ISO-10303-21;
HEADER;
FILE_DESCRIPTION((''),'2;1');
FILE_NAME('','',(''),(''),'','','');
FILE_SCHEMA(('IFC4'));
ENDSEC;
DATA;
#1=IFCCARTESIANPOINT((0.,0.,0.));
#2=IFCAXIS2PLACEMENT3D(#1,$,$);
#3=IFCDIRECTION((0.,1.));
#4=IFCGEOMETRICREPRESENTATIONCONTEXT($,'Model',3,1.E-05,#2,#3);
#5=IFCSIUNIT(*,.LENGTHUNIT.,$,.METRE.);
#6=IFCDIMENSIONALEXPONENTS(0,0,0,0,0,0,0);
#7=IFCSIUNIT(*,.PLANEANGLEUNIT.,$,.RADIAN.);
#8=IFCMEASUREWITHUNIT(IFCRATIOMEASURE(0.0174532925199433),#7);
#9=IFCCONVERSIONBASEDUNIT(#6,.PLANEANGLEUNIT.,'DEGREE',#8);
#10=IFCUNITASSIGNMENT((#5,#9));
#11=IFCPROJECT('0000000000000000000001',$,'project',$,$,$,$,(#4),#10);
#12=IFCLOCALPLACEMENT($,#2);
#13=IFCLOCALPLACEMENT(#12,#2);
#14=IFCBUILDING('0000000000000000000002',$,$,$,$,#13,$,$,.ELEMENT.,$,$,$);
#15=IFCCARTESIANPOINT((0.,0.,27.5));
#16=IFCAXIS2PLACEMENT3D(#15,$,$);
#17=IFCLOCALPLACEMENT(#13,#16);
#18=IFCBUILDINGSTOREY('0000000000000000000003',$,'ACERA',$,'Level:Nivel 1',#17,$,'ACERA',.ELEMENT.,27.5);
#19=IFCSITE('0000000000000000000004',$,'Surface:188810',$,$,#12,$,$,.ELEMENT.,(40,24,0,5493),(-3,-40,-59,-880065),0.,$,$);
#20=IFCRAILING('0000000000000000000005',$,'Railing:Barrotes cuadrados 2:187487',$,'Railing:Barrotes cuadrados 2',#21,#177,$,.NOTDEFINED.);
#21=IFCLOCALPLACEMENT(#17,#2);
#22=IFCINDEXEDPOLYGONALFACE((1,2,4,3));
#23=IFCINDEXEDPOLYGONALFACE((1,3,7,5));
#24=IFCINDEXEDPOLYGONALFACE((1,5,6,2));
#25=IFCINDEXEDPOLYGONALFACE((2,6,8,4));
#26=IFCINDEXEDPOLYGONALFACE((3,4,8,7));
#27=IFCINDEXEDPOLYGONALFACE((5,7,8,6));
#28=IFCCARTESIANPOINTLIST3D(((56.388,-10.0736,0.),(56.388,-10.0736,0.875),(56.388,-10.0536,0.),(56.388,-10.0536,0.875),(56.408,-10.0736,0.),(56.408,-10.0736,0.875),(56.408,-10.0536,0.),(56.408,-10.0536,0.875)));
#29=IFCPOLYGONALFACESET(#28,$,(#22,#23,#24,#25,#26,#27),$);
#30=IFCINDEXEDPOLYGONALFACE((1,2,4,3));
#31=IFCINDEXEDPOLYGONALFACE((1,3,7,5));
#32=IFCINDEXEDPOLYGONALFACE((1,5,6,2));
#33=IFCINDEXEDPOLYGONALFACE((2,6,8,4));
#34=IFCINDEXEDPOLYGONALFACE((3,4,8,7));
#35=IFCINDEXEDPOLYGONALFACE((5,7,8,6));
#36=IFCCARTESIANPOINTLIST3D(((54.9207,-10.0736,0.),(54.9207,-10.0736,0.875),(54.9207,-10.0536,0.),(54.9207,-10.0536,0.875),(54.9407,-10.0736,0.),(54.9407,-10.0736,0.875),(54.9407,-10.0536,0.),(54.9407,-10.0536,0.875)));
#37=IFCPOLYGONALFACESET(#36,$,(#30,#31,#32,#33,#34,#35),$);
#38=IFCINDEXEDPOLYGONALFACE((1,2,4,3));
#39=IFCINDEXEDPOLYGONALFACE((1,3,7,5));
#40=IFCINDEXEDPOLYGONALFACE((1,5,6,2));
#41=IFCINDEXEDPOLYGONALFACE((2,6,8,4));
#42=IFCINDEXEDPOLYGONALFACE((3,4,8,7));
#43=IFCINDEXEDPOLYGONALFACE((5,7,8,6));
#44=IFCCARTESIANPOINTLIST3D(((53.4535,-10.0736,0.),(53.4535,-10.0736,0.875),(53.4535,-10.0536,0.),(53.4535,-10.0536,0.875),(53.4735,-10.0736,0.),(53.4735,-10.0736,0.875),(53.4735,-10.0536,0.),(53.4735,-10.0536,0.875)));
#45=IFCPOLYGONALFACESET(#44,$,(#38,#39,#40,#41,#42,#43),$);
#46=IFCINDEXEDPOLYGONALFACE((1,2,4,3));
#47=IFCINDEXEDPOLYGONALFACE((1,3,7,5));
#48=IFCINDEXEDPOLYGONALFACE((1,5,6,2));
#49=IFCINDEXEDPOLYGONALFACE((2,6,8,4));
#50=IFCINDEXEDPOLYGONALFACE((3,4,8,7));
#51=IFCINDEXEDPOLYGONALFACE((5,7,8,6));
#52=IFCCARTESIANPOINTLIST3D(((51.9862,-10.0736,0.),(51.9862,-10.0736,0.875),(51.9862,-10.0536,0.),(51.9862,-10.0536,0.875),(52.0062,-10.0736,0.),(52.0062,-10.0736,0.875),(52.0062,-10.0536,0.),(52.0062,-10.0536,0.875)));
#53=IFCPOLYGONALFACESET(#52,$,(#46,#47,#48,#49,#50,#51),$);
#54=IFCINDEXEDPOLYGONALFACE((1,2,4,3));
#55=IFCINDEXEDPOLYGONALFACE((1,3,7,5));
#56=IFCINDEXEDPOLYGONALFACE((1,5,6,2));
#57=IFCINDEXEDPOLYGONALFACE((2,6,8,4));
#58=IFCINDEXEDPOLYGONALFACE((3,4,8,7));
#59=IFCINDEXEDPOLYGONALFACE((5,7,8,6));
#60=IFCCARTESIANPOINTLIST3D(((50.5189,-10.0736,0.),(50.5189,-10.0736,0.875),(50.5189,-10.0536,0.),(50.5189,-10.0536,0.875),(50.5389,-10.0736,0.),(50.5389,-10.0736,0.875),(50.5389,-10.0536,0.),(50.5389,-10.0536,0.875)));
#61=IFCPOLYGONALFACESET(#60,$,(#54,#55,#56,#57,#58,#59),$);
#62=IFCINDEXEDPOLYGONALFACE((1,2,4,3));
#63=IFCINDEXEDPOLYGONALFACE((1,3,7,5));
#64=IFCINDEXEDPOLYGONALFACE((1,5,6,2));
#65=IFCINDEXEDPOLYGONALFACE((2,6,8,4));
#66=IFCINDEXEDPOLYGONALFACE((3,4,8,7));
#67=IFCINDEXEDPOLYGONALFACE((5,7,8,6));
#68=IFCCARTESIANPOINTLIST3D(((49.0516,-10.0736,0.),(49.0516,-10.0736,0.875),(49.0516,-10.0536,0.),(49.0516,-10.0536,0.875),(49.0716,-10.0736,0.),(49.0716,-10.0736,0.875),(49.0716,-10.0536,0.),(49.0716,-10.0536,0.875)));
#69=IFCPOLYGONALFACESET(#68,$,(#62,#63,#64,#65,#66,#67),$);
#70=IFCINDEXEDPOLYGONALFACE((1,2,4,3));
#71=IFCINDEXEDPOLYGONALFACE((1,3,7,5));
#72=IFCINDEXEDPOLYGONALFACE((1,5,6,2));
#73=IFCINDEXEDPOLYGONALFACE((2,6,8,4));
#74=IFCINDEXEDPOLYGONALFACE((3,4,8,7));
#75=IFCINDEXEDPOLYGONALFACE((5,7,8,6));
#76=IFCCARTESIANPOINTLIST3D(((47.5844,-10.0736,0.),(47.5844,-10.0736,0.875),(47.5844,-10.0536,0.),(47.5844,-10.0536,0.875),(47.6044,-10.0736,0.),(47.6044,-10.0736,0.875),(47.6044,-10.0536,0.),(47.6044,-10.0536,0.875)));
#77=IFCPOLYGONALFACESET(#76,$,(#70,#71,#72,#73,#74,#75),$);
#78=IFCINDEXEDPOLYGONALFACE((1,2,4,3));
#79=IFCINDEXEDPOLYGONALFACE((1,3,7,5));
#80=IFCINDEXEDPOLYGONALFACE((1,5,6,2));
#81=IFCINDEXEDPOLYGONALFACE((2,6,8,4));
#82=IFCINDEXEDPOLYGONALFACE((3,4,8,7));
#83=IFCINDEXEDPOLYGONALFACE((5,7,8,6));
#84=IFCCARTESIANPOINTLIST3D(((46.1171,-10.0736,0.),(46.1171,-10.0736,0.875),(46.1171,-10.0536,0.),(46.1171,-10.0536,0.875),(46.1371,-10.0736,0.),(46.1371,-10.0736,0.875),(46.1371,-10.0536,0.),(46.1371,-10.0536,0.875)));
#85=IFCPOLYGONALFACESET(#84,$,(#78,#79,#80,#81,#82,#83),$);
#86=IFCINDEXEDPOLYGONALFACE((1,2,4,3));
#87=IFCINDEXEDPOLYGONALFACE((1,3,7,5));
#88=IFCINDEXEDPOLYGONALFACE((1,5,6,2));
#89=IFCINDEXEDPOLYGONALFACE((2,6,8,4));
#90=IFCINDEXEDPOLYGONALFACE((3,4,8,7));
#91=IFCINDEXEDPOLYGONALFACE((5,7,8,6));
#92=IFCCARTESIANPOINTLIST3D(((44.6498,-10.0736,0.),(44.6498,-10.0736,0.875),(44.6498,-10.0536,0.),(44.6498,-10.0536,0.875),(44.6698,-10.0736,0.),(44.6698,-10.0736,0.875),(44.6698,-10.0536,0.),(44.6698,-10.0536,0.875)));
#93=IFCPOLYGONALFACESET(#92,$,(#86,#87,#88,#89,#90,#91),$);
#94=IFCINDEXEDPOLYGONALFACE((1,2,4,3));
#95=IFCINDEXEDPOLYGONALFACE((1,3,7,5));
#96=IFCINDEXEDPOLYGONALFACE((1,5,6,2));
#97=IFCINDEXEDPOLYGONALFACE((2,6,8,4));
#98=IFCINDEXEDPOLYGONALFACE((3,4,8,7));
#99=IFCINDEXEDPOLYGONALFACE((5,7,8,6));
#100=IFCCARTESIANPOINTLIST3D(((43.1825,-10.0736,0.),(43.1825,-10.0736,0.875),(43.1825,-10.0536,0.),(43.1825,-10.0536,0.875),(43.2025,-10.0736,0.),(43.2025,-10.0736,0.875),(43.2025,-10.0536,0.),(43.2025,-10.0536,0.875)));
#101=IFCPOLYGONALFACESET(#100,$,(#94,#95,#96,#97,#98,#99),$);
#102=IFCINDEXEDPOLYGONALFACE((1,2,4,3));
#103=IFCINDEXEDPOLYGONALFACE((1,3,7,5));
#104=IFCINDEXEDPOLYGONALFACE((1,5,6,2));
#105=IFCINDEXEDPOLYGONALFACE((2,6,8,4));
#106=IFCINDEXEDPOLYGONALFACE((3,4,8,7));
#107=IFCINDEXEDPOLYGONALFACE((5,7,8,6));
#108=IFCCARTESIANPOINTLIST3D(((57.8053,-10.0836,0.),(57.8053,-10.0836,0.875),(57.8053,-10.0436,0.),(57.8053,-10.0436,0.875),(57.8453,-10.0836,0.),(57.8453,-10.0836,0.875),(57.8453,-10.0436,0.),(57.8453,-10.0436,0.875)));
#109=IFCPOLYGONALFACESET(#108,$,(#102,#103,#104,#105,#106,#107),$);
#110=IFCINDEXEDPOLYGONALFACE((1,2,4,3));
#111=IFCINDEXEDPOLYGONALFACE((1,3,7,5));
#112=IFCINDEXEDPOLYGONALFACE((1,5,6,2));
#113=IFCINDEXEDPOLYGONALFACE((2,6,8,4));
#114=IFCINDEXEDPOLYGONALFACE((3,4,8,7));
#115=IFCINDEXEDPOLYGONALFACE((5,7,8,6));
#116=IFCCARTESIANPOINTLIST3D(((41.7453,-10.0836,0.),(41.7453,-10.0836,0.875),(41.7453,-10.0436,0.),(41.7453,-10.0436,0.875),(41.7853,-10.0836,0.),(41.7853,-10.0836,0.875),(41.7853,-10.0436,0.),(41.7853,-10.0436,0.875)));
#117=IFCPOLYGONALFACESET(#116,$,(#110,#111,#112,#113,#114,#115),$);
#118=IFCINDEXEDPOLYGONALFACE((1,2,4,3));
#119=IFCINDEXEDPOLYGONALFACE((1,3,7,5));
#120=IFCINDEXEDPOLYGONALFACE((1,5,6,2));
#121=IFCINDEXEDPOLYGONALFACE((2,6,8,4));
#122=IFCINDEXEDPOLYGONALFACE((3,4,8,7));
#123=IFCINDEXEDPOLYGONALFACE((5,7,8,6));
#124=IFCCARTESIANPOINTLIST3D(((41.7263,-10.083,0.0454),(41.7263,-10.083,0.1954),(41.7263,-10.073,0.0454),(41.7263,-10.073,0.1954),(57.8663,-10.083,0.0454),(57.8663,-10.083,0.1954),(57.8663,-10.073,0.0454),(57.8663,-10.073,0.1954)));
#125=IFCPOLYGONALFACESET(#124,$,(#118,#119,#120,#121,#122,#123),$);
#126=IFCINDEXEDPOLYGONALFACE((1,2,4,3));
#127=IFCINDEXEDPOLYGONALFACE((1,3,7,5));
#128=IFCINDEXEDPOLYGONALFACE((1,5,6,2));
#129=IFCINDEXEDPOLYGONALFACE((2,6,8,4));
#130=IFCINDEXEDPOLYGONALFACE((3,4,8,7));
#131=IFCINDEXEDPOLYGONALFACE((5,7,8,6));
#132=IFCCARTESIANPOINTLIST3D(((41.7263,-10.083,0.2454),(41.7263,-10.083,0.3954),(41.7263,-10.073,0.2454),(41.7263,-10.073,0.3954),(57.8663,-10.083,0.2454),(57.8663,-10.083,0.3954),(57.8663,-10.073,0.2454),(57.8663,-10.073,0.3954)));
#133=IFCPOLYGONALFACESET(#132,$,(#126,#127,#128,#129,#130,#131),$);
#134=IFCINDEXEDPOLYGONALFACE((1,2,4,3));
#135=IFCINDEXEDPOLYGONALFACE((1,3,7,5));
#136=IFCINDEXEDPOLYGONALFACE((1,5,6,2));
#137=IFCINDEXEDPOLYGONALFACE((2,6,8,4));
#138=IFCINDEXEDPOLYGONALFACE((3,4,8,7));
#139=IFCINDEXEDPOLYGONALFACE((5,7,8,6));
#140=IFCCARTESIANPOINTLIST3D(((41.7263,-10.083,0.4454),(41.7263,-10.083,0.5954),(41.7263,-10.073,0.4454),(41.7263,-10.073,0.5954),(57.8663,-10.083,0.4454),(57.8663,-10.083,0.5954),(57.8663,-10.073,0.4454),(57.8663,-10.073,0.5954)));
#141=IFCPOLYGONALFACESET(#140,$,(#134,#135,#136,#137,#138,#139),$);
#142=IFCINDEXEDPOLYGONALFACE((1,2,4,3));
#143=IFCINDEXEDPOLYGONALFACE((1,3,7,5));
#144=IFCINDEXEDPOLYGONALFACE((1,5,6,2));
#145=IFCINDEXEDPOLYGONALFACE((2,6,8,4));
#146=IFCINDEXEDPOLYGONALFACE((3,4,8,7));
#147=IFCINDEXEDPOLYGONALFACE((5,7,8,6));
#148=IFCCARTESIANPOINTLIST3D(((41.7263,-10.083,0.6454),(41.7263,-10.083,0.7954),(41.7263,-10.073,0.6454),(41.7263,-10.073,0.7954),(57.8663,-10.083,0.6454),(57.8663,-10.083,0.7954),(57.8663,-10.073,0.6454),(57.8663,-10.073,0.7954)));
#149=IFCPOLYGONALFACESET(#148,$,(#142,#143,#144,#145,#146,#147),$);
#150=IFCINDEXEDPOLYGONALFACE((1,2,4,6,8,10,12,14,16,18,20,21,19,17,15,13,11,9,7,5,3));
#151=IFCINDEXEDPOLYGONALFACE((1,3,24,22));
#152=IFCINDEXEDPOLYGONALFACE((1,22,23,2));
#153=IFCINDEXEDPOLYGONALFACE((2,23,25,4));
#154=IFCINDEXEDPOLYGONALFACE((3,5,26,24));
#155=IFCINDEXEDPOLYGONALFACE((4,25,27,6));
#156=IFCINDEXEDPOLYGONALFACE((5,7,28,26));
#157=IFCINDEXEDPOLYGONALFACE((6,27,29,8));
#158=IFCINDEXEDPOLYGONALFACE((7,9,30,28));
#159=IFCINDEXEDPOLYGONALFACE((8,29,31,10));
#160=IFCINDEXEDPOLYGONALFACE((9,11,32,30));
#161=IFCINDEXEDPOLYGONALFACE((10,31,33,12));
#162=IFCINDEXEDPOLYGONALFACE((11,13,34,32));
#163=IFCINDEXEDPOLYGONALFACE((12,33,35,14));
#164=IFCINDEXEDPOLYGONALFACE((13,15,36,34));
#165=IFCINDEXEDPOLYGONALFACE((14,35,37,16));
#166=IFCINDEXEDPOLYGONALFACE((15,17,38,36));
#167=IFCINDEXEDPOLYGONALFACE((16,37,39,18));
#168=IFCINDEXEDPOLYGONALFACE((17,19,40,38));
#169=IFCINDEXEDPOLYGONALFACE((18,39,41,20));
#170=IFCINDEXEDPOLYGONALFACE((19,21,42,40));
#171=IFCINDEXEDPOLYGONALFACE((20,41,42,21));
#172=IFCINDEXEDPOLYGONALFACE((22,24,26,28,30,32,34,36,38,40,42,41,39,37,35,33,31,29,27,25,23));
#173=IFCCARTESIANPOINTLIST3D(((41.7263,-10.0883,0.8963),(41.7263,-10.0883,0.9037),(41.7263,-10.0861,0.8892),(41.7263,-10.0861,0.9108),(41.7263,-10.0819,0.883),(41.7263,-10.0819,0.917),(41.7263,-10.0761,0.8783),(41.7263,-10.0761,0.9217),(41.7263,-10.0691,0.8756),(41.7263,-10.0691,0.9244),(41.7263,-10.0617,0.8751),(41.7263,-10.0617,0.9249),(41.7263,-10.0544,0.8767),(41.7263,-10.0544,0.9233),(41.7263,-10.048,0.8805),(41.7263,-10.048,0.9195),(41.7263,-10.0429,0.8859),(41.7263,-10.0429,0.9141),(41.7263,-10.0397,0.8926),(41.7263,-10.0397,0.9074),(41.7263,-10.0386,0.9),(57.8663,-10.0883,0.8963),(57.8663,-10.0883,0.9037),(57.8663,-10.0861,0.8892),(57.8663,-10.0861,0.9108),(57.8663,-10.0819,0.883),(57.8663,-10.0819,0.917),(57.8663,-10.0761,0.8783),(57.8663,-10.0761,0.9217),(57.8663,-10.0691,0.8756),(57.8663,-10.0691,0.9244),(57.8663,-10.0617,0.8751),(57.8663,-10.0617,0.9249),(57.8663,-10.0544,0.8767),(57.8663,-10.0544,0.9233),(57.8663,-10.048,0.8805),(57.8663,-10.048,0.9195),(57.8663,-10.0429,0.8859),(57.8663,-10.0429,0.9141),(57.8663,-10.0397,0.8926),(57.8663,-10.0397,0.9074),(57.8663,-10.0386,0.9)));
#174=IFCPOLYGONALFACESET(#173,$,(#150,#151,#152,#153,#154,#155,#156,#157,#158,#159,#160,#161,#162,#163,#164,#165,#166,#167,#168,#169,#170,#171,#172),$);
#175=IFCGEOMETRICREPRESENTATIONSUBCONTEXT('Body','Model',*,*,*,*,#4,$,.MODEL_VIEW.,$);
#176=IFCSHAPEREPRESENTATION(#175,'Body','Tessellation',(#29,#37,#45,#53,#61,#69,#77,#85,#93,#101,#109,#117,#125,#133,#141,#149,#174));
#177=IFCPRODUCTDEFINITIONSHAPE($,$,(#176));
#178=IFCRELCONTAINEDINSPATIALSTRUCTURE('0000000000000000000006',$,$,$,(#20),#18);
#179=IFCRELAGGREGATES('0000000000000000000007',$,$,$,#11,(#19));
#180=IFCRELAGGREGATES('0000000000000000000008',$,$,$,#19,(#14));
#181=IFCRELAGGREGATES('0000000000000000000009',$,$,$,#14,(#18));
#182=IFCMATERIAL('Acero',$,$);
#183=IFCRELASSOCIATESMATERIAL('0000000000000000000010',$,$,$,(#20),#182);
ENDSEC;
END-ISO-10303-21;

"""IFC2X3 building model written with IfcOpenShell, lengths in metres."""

from ifc_helpers import new_model, entity, si_unit, converted_unit, direction, frame, frame_2d, origin, origin_2d_with_axis, place, context, subcontext, project, spatial, rectangle, circle, extrude, material, element, save


model = new_model("IFC2X3")

# Units and contexts
model_context = context("Model", 3, precision=1e-05, world=origin(), true_north=direction((0.0, 1.0)))
body_context = subcontext(model_context, "Body", "Model", "MODEL_VIEW")
ifc_project = project(units=[si_unit("LENGTHUNIT", "METRE"), converted_unit("PLANEANGLEUNIT", "DEGREE", entity("IfcRatioMeasure", 0.0174532925199433), si_unit("PLANEANGLEUNIT", "RADIAN"), dimensions=[0, 0, 0, 0, 0, 0, 0])], contexts=[model_context])

# Site, building, storey
site_placement = place(None, origin())
site = spatial("IfcSite", under=ifc_project, at=site_placement, Name="Surface:188810", CompositionType="ELEMENT", RefLatitude=(40, 24, 0, 5493), RefLongitude=(-3, -40, -59, -880065), RefElevation=0.0)
building_placement = place(site_placement, origin())
building = spatial("IfcBuilding", under=site, at=building_placement, CompositionType="ELEMENT")
storey_placement = place(building_placement, frame((0.0, 0.0, 27.5)))
storey = spatial("IfcBuildingStorey", under=building, at=storey_placement, Name="ACERA", ObjectType="Level:Nivel 1", LongName="ACERA", CompositionType="ELEMENT", Elevation=27.5)

# Railing
ifc_material_1 = material(Name="Acero")
railing_1_placement = place(storey_placement, origin())
element("IfcRailing", 1, at=railing_1_placement, inside=storey, material=ifc_material_1, Name="Railing:Barrotes cuadrados 2:187487", ObjectType="Railing:Barrotes cuadrados 2", PredefinedType="NOTDEFINED", context=body_context, shape_type="SweptSolid", body=[
    extrude(rectangle(XDim=0.02, YDim=0.02, at=frame_2d((0.0, 0.0), x_axis=(1.0, 0.0))), frame((56.398, -10.0636, 0.0), z_axis=(0.0, 0.0, 1.0), x_axis=(0.0, -1.0, 0.0)), (0.0, 0.0, 1.0), 0.875),
    extrude(rectangle(XDim=0.02, YDim=0.02, at=frame_2d((0.0, 0.0), x_axis=(1.0, 0.0))), frame((54.9307, -10.0636, 0.0), z_axis=(0.0, 0.0, 1.0), x_axis=(0.0, -1.0, 0.0)), (0.0, 0.0, 1.0), 0.875),
    extrude(rectangle(XDim=0.02, YDim=0.02, at=frame_2d((0.0, 0.0), x_axis=(1.0, 0.0))), frame((53.4635, -10.0636, 0.0), z_axis=(0.0, 0.0, 1.0), x_axis=(0.0, -1.0, 0.0)), (0.0, 0.0, 1.0), 0.875),
    extrude(rectangle(XDim=0.02, YDim=0.02, at=frame_2d((0.0, 0.0), x_axis=(1.0, 0.0))), frame((51.9962, -10.0636, 0.0), z_axis=(0.0, 0.0, 1.0), x_axis=(0.0, -1.0, 0.0)), (0.0, 0.0, 1.0), 0.875),
    extrude(rectangle(XDim=0.02, YDim=0.02, at=frame_2d((0.0, 0.0), x_axis=(1.0, 0.0))), frame((50.5289, -10.0636, 0.0), z_axis=(0.0, 0.0, 1.0), x_axis=(0.0, -1.0, 0.0)), (0.0, 0.0, 1.0), 0.875),
    extrude(rectangle(XDim=0.02, YDim=0.02, at=frame_2d((0.0, 0.0), x_axis=(1.0, 0.0))), frame((49.0616, -10.0636, 0.0), z_axis=(0.0, 0.0, 1.0), x_axis=(0.0, -1.0, 0.0)), (0.0, 0.0, 1.0), 0.875),
    extrude(rectangle(XDim=0.02, YDim=0.02, at=frame_2d((0.0, 0.0), x_axis=(1.0, 0.0))), frame((47.5944, -10.0636, 0.0), z_axis=(0.0, 0.0, 1.0), x_axis=(0.0, -1.0, 0.0)), (0.0, 0.0, 1.0), 0.875),
    extrude(rectangle(XDim=0.02, YDim=0.02, at=frame_2d((0.0, 0.0), x_axis=(1.0, 0.0))), frame((46.1271, -10.0636, 0.0), z_axis=(0.0, 0.0, 1.0), x_axis=(0.0, -1.0, 0.0)), (0.0, 0.0, 1.0), 0.875),
    extrude(rectangle(XDim=0.02, YDim=0.02, at=frame_2d((0.0, 0.0), x_axis=(1.0, 0.0))), frame((44.6598, -10.0636, 0.0), z_axis=(0.0, 0.0, 1.0), x_axis=(0.0, -1.0, 0.0)), (0.0, 0.0, 1.0), 0.875),
    extrude(rectangle(XDim=0.02, YDim=0.02, at=frame_2d((0.0, 0.0), x_axis=(1.0, 0.0))), frame((43.1925, -10.0636, 0.0), z_axis=(0.0, 0.0, 1.0), x_axis=(0.0, -1.0, 0.0)), (0.0, 0.0, 1.0), 0.875),
    extrude(rectangle(XDim=0.04, YDim=0.04, at=frame_2d((0.0, 0.0), x_axis=(1.0, 0.0))), frame((57.8253, -10.0636, 0.0), z_axis=(0.0, 0.0, 1.0), x_axis=(0.0, -1.0, 0.0)), (0.0, 0.0, 1.0), 0.875),
    extrude(rectangle(XDim=0.04, YDim=0.04, at=frame_2d((0.0, 0.0), x_axis=(1.0, 0.0))), frame((41.7653, -10.0636, 0.0), z_axis=(0.0, 0.0, 1.0), x_axis=(0.0, -1.0, 0.0)), (0.0, 0.0, 1.0), 0.875),
    extrude(rectangle(XDim=16.14, YDim=0.01, at=frame_2d((0.0, 0.0), x_axis=(1.0, 0.0))), frame((49.7963, -10.078, 0.0454)), (0.0, 0.0, 1.0), 0.15),
    extrude(rectangle(XDim=16.14, YDim=0.01, at=frame_2d((0.0, 0.0), x_axis=(1.0, 0.0))), frame((49.7963, -10.078, 0.2454)), (0.0, 0.0, 1.0), 0.15),
    extrude(rectangle(XDim=16.14, YDim=0.01, at=frame_2d((0.0, 0.0), x_axis=(1.0, 0.0))), frame((49.7963, -10.078, 0.4454)), (0.0, 0.0, 1.0), 0.15),
    extrude(rectangle(XDim=16.14, YDim=0.01, at=frame_2d((0.0, 0.0), x_axis=(1.0, 0.0))), frame((49.7963, -10.078, 0.6454)), (0.0, 0.0, 1.0), 0.15),
    extrude(circle(Radius=0.025, at=origin_2d_with_axis()), frame((41.7263, -10.0636, 0.9), z_axis=(1.0, 0.0, 0.0), x_axis=(0.0, 1.0, 0.0)), (0.0, 0.0, 1.0), 16.14),
])

save(model, "model.ifc")
